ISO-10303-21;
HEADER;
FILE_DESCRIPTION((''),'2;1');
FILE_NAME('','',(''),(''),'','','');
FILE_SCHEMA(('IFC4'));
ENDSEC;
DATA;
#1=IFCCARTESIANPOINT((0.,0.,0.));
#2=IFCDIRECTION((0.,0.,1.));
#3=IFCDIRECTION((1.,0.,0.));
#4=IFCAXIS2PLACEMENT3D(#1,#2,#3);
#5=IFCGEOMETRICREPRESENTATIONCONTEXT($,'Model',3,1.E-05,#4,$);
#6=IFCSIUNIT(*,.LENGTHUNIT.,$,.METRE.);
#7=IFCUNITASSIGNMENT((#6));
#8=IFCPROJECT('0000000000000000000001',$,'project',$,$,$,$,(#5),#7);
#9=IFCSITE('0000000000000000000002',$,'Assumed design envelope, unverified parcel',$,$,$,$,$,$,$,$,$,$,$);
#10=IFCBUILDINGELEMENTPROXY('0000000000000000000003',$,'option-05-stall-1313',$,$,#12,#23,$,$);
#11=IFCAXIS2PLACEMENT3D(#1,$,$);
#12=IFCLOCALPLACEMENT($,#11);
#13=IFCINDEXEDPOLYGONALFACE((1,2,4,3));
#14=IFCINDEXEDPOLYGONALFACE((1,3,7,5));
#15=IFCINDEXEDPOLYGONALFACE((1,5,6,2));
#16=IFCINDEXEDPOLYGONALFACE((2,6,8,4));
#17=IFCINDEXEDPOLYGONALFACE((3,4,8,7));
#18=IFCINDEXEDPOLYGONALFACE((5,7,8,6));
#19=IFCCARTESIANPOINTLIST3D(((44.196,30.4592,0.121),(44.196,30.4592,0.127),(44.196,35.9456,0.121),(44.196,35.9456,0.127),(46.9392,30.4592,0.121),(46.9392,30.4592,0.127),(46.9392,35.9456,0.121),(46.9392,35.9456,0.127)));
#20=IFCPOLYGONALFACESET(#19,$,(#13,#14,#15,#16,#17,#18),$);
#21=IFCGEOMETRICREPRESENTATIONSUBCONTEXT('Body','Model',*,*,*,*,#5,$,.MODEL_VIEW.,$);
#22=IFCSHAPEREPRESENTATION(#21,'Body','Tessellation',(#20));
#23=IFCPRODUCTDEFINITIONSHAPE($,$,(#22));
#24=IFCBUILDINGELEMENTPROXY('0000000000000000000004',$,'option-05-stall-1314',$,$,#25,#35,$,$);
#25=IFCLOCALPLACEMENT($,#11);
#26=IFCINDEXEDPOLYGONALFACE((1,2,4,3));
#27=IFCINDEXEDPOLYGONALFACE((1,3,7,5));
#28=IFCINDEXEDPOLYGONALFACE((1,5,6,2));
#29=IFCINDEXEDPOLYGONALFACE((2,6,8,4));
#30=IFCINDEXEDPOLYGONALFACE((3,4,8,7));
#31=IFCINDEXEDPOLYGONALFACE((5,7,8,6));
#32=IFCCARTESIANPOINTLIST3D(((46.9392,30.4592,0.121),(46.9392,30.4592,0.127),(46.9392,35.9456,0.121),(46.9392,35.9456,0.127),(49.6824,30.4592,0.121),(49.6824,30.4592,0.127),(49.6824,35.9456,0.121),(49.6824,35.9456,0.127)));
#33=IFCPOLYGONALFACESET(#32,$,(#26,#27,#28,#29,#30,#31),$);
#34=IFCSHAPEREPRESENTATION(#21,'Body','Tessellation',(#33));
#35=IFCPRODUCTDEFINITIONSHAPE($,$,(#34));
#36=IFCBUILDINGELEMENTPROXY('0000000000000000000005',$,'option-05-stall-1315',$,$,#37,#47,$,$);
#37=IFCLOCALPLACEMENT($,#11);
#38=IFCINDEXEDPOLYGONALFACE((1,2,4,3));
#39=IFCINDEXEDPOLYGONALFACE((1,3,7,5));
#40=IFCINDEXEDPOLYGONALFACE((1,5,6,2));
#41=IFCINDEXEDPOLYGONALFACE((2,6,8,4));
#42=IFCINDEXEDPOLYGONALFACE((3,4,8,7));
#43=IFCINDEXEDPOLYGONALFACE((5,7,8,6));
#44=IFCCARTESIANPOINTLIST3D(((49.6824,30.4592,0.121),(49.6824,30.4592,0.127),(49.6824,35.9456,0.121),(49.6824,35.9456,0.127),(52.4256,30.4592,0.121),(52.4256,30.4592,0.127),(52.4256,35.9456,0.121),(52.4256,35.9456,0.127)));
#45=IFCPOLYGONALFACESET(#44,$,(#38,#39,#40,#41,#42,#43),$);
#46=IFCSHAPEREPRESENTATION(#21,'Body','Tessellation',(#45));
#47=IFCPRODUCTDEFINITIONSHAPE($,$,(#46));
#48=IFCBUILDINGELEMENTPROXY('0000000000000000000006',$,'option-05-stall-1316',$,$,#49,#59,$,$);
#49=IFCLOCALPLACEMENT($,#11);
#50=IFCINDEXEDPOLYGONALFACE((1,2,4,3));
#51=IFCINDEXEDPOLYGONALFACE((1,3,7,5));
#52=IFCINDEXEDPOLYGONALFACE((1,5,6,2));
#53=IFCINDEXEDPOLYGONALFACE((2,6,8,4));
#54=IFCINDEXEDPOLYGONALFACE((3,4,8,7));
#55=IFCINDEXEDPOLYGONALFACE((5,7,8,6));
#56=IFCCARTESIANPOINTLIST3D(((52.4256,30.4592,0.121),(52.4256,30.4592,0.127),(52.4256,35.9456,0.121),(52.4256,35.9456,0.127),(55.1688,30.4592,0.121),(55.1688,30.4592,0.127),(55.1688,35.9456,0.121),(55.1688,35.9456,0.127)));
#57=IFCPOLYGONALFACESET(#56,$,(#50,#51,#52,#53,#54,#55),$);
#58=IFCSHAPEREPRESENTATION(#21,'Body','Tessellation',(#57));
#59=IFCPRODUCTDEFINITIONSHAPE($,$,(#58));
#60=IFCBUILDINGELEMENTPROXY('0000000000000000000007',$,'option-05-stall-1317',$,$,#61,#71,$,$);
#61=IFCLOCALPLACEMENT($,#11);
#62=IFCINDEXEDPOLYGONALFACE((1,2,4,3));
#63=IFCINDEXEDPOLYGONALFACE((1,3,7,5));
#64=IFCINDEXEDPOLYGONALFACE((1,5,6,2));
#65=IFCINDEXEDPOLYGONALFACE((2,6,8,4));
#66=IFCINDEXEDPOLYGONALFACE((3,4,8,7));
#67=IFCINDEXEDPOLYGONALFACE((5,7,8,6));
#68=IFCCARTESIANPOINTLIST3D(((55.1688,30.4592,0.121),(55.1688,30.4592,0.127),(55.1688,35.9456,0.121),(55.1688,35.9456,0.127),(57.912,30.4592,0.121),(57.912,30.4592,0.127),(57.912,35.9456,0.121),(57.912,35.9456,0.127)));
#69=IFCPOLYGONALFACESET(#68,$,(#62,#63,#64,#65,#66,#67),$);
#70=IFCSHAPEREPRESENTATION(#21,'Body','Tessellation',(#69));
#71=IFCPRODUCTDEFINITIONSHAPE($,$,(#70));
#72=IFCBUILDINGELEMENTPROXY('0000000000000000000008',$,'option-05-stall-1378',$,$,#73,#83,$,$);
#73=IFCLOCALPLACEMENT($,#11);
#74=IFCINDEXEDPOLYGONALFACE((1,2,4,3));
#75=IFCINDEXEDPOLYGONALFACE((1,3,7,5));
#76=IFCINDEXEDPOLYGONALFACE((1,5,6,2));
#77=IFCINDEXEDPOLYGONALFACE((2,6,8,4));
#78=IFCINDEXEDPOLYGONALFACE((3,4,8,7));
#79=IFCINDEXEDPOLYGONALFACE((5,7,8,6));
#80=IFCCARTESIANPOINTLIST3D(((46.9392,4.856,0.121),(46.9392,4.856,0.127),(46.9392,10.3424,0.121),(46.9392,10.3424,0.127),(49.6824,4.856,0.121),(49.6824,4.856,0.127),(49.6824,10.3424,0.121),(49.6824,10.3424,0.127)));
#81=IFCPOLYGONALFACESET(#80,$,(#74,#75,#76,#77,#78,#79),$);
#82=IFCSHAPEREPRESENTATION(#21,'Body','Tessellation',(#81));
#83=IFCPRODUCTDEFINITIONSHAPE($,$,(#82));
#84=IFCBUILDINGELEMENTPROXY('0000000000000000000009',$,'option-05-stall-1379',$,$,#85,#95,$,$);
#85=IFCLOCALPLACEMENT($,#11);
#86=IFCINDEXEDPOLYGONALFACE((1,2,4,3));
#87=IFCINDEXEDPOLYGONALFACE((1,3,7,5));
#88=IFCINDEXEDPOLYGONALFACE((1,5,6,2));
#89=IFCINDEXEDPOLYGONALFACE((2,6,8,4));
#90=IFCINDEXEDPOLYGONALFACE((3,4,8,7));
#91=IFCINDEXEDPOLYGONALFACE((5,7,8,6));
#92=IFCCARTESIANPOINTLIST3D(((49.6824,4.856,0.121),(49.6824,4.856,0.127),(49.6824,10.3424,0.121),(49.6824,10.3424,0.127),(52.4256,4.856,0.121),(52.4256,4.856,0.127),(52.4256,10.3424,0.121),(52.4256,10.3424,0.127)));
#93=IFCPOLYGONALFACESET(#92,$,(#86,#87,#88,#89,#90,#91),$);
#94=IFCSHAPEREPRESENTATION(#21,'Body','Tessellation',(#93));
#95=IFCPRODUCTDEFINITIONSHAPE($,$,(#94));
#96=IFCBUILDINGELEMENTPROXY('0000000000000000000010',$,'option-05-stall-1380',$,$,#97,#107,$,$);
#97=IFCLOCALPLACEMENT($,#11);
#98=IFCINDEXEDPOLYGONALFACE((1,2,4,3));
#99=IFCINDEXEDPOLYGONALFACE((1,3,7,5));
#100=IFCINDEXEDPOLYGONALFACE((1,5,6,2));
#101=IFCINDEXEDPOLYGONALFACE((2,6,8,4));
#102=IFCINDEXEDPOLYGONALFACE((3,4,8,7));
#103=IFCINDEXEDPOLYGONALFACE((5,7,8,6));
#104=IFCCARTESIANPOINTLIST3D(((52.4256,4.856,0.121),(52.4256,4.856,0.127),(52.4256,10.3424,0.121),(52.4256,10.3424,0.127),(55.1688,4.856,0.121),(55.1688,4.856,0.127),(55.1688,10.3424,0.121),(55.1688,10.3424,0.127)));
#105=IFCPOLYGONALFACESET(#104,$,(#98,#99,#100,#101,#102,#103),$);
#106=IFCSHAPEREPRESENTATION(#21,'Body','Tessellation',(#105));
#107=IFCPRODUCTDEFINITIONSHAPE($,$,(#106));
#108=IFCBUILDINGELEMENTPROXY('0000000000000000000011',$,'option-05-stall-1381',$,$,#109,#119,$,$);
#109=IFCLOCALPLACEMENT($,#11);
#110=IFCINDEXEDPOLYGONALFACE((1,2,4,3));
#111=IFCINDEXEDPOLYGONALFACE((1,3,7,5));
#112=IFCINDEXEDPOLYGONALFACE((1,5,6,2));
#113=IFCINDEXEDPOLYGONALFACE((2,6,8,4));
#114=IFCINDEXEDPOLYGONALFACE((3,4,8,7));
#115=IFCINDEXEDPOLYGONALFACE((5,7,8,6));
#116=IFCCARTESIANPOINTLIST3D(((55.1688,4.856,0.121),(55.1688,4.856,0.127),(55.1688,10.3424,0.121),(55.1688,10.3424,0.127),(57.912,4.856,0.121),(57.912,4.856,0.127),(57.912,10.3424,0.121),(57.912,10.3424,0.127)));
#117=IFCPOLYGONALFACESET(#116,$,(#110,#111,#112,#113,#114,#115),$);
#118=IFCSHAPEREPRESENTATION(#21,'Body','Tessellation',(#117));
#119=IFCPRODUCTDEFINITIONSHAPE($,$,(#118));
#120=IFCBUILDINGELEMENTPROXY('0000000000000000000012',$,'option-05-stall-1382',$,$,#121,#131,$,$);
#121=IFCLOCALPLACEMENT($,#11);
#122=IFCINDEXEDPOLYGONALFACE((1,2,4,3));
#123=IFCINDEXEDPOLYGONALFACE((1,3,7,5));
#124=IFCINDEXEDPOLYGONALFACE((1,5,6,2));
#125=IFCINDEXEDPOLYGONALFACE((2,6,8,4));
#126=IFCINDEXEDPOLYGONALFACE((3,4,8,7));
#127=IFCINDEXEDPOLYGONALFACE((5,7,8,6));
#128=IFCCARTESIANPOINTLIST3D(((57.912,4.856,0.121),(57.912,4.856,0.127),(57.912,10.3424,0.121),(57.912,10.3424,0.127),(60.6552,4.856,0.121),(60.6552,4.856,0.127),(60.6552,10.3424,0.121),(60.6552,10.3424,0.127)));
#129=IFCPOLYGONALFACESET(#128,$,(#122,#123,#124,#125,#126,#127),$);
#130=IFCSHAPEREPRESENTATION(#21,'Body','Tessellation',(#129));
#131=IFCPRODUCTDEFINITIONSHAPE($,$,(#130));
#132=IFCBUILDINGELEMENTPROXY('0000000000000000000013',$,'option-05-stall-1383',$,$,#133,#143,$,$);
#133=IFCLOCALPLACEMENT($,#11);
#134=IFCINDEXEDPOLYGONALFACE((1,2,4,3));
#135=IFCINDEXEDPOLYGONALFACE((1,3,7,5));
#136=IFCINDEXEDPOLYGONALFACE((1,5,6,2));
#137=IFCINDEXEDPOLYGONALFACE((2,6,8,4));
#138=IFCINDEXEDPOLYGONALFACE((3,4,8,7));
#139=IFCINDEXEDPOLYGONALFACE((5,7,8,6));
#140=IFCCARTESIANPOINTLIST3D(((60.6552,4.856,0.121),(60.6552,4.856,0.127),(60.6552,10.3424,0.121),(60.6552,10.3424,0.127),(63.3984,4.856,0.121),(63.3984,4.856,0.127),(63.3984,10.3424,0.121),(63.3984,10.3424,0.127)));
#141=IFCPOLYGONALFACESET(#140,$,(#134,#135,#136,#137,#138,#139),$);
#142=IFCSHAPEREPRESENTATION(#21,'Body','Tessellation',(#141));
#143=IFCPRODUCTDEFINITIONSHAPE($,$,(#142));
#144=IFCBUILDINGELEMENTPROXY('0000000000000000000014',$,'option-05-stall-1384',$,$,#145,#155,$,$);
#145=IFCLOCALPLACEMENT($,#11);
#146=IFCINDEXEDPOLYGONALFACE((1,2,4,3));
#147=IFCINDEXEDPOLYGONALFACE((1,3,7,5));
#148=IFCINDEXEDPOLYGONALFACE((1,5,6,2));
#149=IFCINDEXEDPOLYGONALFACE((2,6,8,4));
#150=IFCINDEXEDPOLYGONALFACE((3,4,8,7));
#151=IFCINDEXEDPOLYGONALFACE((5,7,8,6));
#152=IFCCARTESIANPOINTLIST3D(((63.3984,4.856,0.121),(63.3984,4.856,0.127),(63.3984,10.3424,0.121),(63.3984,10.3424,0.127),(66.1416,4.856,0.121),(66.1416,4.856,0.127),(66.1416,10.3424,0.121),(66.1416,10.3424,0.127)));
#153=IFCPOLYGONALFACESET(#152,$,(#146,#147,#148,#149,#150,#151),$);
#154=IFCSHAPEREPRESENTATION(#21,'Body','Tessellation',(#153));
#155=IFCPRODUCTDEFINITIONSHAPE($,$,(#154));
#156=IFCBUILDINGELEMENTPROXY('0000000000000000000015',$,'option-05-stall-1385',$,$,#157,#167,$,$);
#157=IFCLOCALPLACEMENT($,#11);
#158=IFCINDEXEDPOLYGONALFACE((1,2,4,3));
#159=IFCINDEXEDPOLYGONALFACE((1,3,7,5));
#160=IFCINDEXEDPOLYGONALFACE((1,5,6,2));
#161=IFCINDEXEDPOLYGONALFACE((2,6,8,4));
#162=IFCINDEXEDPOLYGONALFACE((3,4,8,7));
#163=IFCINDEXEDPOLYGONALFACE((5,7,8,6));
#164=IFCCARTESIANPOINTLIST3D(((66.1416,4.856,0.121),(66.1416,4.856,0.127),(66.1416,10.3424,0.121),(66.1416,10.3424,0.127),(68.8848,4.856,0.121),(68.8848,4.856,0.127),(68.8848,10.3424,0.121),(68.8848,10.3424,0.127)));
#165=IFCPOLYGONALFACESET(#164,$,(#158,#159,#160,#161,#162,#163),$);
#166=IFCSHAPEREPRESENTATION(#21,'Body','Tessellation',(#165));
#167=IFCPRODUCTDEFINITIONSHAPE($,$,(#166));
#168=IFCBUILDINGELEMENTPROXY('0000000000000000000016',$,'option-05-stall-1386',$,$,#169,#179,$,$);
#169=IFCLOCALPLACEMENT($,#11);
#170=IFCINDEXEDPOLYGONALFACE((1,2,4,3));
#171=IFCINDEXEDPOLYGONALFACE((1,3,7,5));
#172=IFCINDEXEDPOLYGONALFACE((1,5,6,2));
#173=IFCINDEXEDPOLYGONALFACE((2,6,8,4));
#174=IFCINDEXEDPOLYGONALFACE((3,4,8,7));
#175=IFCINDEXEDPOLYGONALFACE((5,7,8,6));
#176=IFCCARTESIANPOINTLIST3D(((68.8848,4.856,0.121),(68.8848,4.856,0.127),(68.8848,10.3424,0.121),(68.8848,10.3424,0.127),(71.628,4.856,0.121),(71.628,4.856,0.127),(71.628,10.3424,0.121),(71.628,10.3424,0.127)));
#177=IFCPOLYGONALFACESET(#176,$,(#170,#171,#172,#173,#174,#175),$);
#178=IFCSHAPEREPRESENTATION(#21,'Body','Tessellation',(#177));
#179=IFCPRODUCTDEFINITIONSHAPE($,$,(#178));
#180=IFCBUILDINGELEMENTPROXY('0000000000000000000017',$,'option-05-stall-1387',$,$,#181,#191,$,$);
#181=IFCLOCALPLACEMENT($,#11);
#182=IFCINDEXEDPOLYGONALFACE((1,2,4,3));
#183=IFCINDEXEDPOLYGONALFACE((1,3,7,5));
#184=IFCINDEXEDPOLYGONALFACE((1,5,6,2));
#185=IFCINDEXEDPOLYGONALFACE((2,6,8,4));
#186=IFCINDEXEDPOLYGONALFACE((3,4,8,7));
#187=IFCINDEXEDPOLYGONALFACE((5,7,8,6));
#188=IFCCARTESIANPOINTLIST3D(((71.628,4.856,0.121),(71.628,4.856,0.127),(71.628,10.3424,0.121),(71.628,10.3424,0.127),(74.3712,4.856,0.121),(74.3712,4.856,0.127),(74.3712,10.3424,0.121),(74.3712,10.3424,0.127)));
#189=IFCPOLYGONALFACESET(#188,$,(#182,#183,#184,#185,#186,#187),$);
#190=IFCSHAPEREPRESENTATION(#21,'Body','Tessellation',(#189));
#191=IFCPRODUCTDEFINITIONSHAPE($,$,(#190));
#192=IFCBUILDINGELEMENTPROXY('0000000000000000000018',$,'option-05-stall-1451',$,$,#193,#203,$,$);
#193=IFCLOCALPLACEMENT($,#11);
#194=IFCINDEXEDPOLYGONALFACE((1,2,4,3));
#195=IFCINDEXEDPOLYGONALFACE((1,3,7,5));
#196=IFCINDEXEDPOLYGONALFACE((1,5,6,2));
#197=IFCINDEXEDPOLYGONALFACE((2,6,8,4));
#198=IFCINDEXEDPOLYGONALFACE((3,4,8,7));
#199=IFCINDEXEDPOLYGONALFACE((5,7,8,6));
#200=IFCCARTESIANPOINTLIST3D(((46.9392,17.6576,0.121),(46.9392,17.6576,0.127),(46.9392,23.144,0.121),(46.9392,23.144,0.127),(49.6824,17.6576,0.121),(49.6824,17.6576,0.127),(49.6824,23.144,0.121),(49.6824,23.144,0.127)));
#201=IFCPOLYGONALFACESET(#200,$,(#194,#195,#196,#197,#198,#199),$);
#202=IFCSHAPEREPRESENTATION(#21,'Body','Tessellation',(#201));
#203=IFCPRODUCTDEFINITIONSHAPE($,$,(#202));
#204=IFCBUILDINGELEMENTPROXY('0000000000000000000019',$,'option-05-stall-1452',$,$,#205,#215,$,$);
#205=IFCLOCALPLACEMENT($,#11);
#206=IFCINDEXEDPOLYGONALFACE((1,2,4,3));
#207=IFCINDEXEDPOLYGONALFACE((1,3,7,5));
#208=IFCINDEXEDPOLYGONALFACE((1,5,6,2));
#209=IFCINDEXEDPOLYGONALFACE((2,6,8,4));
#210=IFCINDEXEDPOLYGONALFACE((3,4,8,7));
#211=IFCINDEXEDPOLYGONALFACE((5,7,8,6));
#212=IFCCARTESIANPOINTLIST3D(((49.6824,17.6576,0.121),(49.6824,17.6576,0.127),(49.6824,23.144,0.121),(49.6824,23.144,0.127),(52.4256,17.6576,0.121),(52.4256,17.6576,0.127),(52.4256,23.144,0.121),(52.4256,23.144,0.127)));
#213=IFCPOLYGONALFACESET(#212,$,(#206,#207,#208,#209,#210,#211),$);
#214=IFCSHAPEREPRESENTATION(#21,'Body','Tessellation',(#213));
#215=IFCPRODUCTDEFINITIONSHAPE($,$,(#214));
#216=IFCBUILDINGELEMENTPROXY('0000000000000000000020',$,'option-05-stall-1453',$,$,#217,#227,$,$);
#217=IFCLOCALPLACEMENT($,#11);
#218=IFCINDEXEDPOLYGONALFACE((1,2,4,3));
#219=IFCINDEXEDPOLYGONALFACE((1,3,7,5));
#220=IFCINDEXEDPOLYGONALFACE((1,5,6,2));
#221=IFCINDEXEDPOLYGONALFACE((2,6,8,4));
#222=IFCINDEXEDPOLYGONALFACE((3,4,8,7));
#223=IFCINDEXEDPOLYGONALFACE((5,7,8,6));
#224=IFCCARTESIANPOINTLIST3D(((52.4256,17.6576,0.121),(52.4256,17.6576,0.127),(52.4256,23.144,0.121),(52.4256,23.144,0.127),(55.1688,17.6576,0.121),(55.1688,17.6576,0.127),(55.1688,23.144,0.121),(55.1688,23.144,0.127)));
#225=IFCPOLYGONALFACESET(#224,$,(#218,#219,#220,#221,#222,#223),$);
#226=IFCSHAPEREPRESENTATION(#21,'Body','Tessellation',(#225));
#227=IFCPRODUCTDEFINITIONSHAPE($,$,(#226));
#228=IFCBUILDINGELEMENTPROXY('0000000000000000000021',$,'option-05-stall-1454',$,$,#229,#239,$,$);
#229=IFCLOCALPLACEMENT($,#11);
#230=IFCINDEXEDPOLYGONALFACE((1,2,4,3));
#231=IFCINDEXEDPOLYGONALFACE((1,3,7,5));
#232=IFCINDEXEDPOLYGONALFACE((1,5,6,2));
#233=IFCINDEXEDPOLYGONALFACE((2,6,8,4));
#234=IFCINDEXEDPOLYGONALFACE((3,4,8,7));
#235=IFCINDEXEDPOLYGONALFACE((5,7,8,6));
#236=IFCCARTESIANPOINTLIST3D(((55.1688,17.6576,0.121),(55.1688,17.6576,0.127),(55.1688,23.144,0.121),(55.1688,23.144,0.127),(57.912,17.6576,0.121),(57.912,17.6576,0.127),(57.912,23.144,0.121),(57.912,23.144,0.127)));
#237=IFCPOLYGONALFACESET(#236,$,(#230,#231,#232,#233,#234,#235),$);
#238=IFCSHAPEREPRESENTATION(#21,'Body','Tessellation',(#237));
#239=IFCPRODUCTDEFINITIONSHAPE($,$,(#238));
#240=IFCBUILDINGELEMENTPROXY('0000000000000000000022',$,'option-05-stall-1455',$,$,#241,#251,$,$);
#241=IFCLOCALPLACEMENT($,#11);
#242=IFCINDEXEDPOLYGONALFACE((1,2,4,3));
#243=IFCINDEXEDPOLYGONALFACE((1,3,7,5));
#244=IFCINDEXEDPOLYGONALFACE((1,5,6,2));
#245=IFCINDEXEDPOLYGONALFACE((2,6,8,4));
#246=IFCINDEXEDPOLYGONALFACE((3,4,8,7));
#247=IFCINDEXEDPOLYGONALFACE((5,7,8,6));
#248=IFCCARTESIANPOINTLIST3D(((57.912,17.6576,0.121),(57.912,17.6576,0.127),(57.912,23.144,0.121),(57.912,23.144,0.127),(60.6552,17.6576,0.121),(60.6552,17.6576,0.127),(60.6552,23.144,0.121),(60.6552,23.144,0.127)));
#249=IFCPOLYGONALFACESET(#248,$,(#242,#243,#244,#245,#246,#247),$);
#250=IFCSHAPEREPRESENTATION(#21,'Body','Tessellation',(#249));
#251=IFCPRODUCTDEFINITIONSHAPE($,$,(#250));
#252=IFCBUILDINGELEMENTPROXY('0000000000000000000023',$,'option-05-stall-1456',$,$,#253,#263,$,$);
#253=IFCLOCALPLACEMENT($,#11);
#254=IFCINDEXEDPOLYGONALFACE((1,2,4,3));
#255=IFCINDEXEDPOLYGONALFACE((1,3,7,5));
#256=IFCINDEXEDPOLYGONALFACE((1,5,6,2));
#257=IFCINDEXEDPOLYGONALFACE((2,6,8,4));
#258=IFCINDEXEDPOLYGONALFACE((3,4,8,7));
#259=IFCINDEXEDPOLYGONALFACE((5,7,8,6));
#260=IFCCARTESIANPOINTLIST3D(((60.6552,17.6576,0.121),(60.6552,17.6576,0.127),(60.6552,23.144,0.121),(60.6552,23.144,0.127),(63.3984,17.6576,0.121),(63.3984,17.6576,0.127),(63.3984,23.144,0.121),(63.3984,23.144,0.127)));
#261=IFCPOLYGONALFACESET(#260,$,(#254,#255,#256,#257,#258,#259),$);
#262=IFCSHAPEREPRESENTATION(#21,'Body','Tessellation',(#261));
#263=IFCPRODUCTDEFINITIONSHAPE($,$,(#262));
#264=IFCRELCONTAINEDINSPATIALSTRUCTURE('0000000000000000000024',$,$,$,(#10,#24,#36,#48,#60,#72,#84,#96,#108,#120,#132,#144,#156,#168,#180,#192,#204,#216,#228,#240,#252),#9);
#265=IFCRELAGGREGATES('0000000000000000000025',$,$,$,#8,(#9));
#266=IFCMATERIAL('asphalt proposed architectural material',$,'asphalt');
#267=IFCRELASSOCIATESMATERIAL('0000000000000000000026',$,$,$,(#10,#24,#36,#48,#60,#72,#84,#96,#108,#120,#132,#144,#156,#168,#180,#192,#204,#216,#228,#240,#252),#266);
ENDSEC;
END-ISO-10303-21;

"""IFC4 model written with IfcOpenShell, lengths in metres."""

from ifc_helpers import new_model, si_unit, frame, origin_with_axes, place, context, subcontext, project, spatial, rectangle, extrude, material, element, save


model = new_model("IFC4")

# Units and contexts
model_context = context("Model", 3, precision=1e-05, world=origin_with_axes())
body_context = subcontext(model_context, "Body", "Model", "MODEL_VIEW")
ifc_project = project(units=[si_unit("LENGTHUNIT", "METRE")], contexts=[model_context])

# Site
site = spatial("IfcSite", under=ifc_project, Name="Assumed design envelope, unverified parcel")

# Building element proxies
ifc_material = material(Name="asphalt proposed architectural material", Category="asphalt")
for number, where, z_axis, x_axis, name in (
    (1, (45.5676, 33.2024, 0.121), (0.0, 0.0, 1.0), (1.0, 0.0, 0.0), "option-05-stall-1313"),
    (2, (48.3108, 33.2024, 0.121), (0.0, 0.0, 1.0), (1.0, 0.0, 0.0), "option-05-stall-1314"),
    (3, (51.054, 33.2024, 0.121), (0.0, 0.0, 1.0), (1.0, 0.0, 0.0), "option-05-stall-1315"),
    (4, (53.7972, 33.2024, 0.121), (0.0, 0.0, 1.0), (1.0, 0.0, 0.0), "option-05-stall-1316"),
    (5, (56.5404, 33.2024, 0.121), (0.0, 0.0, 1.0), (1.0, 0.0, 0.0), "option-05-stall-1317"),
):
    element("IfcBuildingElementProxy", number, at=place(None, frame(where, z_axis=z_axis, x_axis=x_axis)), inside=site, material=ifc_material, Name=name, context=body_context, shape_type="SweptSolid", body=[
        extrude(rectangle(XDim=2.7432, YDim=5.4864), origin_with_axes(), (0.0, 0.0, 1.0), 0.006),
    ])
for number, where, z_axis, x_axis, name in (
    (6, (48.3108, 7.5992, 0.121), (0.0, 0.0, 1.0), (1.0, 0.0, 0.0), "option-05-stall-1378"),
    (7, (51.054, 7.5992, 0.121), (0.0, 0.0, 1.0), (1.0, 0.0, 0.0), "option-05-stall-1379"),
    (8, (53.7972, 7.5992, 0.121), (0.0, 0.0, 1.0), (1.0, 0.0, 0.0), "option-05-stall-1380"),
    (9, (56.5404, 7.5992, 0.121), (0.0, 0.0, 1.0), (1.0, 0.0, 0.0), "option-05-stall-1381"),
    (10, (59.2836, 7.5992, 0.121), (0.0, 0.0, 1.0), (1.0, 0.0, 0.0), "option-05-stall-1382"),
    (11, (62.0268, 7.5992, 0.121), (0.0, 0.0, 1.0), (1.0, 0.0, 0.0), "option-05-stall-1383"),
    (12, (64.77, 7.5992, 0.121), (0.0, 0.0, 1.0), (1.0, 0.0, 0.0), "option-05-stall-1384"),
    (13, (67.5132, 7.5992, 0.121), (0.0, 0.0, 1.0), (1.0, 0.0, 0.0), "option-05-stall-1385"),
    (14, (70.2564, 7.5992, 0.121), (0.0, 0.0, 1.0), (1.0, 0.0, 0.0), "option-05-stall-1386"),
    (15, (72.9996, 7.5992, 0.121), (0.0, 0.0, 1.0), (1.0, 0.0, 0.0), "option-05-stall-1387"),
):
    element("IfcBuildingElementProxy", number, at=place(None, frame(where, z_axis=z_axis, x_axis=x_axis)), inside=site, material=ifc_material, Name=name, context=body_context, shape_type="SweptSolid", body=[
        extrude(rectangle(XDim=2.7432, YDim=5.4864), origin_with_axes(), (0.0, 0.0, 1.0), 0.006),
    ])
for number, where, z_axis, x_axis, name in (
    (16, (48.3108, 20.4008, 0.121), (0.0, 0.0, 1.0), (1.0, 0.0, 0.0), "option-05-stall-1451"),
    (17, (51.054, 20.4008, 0.121), (0.0, 0.0, 1.0), (1.0, 0.0, 0.0), "option-05-stall-1452"),
    (18, (53.7972, 20.4008, 0.121), (0.0, 0.0, 1.0), (1.0, 0.0, 0.0), "option-05-stall-1453"),
    (19, (56.5404, 20.4008, 0.121), (0.0, 0.0, 1.0), (1.0, 0.0, 0.0), "option-05-stall-1454"),
    (20, (59.2836, 20.4008, 0.121), (0.0, 0.0, 1.0), (1.0, 0.0, 0.0), "option-05-stall-1455"),
    (21, (62.0268, 20.4008, 0.121), (0.0, 0.0, 1.0), (1.0, 0.0, 0.0), "option-05-stall-1456"),
):
    element("IfcBuildingElementProxy", number, at=place(None, frame(where, z_axis=z_axis, x_axis=x_axis)), inside=site, material=ifc_material, Name=name, context=body_context, shape_type="SweptSolid", body=[
        extrude(rectangle(XDim=2.7432, YDim=5.4864), origin_with_axes(), (0.0, 0.0, 1.0), 0.006),
    ])

save(model, "model.ifc")
